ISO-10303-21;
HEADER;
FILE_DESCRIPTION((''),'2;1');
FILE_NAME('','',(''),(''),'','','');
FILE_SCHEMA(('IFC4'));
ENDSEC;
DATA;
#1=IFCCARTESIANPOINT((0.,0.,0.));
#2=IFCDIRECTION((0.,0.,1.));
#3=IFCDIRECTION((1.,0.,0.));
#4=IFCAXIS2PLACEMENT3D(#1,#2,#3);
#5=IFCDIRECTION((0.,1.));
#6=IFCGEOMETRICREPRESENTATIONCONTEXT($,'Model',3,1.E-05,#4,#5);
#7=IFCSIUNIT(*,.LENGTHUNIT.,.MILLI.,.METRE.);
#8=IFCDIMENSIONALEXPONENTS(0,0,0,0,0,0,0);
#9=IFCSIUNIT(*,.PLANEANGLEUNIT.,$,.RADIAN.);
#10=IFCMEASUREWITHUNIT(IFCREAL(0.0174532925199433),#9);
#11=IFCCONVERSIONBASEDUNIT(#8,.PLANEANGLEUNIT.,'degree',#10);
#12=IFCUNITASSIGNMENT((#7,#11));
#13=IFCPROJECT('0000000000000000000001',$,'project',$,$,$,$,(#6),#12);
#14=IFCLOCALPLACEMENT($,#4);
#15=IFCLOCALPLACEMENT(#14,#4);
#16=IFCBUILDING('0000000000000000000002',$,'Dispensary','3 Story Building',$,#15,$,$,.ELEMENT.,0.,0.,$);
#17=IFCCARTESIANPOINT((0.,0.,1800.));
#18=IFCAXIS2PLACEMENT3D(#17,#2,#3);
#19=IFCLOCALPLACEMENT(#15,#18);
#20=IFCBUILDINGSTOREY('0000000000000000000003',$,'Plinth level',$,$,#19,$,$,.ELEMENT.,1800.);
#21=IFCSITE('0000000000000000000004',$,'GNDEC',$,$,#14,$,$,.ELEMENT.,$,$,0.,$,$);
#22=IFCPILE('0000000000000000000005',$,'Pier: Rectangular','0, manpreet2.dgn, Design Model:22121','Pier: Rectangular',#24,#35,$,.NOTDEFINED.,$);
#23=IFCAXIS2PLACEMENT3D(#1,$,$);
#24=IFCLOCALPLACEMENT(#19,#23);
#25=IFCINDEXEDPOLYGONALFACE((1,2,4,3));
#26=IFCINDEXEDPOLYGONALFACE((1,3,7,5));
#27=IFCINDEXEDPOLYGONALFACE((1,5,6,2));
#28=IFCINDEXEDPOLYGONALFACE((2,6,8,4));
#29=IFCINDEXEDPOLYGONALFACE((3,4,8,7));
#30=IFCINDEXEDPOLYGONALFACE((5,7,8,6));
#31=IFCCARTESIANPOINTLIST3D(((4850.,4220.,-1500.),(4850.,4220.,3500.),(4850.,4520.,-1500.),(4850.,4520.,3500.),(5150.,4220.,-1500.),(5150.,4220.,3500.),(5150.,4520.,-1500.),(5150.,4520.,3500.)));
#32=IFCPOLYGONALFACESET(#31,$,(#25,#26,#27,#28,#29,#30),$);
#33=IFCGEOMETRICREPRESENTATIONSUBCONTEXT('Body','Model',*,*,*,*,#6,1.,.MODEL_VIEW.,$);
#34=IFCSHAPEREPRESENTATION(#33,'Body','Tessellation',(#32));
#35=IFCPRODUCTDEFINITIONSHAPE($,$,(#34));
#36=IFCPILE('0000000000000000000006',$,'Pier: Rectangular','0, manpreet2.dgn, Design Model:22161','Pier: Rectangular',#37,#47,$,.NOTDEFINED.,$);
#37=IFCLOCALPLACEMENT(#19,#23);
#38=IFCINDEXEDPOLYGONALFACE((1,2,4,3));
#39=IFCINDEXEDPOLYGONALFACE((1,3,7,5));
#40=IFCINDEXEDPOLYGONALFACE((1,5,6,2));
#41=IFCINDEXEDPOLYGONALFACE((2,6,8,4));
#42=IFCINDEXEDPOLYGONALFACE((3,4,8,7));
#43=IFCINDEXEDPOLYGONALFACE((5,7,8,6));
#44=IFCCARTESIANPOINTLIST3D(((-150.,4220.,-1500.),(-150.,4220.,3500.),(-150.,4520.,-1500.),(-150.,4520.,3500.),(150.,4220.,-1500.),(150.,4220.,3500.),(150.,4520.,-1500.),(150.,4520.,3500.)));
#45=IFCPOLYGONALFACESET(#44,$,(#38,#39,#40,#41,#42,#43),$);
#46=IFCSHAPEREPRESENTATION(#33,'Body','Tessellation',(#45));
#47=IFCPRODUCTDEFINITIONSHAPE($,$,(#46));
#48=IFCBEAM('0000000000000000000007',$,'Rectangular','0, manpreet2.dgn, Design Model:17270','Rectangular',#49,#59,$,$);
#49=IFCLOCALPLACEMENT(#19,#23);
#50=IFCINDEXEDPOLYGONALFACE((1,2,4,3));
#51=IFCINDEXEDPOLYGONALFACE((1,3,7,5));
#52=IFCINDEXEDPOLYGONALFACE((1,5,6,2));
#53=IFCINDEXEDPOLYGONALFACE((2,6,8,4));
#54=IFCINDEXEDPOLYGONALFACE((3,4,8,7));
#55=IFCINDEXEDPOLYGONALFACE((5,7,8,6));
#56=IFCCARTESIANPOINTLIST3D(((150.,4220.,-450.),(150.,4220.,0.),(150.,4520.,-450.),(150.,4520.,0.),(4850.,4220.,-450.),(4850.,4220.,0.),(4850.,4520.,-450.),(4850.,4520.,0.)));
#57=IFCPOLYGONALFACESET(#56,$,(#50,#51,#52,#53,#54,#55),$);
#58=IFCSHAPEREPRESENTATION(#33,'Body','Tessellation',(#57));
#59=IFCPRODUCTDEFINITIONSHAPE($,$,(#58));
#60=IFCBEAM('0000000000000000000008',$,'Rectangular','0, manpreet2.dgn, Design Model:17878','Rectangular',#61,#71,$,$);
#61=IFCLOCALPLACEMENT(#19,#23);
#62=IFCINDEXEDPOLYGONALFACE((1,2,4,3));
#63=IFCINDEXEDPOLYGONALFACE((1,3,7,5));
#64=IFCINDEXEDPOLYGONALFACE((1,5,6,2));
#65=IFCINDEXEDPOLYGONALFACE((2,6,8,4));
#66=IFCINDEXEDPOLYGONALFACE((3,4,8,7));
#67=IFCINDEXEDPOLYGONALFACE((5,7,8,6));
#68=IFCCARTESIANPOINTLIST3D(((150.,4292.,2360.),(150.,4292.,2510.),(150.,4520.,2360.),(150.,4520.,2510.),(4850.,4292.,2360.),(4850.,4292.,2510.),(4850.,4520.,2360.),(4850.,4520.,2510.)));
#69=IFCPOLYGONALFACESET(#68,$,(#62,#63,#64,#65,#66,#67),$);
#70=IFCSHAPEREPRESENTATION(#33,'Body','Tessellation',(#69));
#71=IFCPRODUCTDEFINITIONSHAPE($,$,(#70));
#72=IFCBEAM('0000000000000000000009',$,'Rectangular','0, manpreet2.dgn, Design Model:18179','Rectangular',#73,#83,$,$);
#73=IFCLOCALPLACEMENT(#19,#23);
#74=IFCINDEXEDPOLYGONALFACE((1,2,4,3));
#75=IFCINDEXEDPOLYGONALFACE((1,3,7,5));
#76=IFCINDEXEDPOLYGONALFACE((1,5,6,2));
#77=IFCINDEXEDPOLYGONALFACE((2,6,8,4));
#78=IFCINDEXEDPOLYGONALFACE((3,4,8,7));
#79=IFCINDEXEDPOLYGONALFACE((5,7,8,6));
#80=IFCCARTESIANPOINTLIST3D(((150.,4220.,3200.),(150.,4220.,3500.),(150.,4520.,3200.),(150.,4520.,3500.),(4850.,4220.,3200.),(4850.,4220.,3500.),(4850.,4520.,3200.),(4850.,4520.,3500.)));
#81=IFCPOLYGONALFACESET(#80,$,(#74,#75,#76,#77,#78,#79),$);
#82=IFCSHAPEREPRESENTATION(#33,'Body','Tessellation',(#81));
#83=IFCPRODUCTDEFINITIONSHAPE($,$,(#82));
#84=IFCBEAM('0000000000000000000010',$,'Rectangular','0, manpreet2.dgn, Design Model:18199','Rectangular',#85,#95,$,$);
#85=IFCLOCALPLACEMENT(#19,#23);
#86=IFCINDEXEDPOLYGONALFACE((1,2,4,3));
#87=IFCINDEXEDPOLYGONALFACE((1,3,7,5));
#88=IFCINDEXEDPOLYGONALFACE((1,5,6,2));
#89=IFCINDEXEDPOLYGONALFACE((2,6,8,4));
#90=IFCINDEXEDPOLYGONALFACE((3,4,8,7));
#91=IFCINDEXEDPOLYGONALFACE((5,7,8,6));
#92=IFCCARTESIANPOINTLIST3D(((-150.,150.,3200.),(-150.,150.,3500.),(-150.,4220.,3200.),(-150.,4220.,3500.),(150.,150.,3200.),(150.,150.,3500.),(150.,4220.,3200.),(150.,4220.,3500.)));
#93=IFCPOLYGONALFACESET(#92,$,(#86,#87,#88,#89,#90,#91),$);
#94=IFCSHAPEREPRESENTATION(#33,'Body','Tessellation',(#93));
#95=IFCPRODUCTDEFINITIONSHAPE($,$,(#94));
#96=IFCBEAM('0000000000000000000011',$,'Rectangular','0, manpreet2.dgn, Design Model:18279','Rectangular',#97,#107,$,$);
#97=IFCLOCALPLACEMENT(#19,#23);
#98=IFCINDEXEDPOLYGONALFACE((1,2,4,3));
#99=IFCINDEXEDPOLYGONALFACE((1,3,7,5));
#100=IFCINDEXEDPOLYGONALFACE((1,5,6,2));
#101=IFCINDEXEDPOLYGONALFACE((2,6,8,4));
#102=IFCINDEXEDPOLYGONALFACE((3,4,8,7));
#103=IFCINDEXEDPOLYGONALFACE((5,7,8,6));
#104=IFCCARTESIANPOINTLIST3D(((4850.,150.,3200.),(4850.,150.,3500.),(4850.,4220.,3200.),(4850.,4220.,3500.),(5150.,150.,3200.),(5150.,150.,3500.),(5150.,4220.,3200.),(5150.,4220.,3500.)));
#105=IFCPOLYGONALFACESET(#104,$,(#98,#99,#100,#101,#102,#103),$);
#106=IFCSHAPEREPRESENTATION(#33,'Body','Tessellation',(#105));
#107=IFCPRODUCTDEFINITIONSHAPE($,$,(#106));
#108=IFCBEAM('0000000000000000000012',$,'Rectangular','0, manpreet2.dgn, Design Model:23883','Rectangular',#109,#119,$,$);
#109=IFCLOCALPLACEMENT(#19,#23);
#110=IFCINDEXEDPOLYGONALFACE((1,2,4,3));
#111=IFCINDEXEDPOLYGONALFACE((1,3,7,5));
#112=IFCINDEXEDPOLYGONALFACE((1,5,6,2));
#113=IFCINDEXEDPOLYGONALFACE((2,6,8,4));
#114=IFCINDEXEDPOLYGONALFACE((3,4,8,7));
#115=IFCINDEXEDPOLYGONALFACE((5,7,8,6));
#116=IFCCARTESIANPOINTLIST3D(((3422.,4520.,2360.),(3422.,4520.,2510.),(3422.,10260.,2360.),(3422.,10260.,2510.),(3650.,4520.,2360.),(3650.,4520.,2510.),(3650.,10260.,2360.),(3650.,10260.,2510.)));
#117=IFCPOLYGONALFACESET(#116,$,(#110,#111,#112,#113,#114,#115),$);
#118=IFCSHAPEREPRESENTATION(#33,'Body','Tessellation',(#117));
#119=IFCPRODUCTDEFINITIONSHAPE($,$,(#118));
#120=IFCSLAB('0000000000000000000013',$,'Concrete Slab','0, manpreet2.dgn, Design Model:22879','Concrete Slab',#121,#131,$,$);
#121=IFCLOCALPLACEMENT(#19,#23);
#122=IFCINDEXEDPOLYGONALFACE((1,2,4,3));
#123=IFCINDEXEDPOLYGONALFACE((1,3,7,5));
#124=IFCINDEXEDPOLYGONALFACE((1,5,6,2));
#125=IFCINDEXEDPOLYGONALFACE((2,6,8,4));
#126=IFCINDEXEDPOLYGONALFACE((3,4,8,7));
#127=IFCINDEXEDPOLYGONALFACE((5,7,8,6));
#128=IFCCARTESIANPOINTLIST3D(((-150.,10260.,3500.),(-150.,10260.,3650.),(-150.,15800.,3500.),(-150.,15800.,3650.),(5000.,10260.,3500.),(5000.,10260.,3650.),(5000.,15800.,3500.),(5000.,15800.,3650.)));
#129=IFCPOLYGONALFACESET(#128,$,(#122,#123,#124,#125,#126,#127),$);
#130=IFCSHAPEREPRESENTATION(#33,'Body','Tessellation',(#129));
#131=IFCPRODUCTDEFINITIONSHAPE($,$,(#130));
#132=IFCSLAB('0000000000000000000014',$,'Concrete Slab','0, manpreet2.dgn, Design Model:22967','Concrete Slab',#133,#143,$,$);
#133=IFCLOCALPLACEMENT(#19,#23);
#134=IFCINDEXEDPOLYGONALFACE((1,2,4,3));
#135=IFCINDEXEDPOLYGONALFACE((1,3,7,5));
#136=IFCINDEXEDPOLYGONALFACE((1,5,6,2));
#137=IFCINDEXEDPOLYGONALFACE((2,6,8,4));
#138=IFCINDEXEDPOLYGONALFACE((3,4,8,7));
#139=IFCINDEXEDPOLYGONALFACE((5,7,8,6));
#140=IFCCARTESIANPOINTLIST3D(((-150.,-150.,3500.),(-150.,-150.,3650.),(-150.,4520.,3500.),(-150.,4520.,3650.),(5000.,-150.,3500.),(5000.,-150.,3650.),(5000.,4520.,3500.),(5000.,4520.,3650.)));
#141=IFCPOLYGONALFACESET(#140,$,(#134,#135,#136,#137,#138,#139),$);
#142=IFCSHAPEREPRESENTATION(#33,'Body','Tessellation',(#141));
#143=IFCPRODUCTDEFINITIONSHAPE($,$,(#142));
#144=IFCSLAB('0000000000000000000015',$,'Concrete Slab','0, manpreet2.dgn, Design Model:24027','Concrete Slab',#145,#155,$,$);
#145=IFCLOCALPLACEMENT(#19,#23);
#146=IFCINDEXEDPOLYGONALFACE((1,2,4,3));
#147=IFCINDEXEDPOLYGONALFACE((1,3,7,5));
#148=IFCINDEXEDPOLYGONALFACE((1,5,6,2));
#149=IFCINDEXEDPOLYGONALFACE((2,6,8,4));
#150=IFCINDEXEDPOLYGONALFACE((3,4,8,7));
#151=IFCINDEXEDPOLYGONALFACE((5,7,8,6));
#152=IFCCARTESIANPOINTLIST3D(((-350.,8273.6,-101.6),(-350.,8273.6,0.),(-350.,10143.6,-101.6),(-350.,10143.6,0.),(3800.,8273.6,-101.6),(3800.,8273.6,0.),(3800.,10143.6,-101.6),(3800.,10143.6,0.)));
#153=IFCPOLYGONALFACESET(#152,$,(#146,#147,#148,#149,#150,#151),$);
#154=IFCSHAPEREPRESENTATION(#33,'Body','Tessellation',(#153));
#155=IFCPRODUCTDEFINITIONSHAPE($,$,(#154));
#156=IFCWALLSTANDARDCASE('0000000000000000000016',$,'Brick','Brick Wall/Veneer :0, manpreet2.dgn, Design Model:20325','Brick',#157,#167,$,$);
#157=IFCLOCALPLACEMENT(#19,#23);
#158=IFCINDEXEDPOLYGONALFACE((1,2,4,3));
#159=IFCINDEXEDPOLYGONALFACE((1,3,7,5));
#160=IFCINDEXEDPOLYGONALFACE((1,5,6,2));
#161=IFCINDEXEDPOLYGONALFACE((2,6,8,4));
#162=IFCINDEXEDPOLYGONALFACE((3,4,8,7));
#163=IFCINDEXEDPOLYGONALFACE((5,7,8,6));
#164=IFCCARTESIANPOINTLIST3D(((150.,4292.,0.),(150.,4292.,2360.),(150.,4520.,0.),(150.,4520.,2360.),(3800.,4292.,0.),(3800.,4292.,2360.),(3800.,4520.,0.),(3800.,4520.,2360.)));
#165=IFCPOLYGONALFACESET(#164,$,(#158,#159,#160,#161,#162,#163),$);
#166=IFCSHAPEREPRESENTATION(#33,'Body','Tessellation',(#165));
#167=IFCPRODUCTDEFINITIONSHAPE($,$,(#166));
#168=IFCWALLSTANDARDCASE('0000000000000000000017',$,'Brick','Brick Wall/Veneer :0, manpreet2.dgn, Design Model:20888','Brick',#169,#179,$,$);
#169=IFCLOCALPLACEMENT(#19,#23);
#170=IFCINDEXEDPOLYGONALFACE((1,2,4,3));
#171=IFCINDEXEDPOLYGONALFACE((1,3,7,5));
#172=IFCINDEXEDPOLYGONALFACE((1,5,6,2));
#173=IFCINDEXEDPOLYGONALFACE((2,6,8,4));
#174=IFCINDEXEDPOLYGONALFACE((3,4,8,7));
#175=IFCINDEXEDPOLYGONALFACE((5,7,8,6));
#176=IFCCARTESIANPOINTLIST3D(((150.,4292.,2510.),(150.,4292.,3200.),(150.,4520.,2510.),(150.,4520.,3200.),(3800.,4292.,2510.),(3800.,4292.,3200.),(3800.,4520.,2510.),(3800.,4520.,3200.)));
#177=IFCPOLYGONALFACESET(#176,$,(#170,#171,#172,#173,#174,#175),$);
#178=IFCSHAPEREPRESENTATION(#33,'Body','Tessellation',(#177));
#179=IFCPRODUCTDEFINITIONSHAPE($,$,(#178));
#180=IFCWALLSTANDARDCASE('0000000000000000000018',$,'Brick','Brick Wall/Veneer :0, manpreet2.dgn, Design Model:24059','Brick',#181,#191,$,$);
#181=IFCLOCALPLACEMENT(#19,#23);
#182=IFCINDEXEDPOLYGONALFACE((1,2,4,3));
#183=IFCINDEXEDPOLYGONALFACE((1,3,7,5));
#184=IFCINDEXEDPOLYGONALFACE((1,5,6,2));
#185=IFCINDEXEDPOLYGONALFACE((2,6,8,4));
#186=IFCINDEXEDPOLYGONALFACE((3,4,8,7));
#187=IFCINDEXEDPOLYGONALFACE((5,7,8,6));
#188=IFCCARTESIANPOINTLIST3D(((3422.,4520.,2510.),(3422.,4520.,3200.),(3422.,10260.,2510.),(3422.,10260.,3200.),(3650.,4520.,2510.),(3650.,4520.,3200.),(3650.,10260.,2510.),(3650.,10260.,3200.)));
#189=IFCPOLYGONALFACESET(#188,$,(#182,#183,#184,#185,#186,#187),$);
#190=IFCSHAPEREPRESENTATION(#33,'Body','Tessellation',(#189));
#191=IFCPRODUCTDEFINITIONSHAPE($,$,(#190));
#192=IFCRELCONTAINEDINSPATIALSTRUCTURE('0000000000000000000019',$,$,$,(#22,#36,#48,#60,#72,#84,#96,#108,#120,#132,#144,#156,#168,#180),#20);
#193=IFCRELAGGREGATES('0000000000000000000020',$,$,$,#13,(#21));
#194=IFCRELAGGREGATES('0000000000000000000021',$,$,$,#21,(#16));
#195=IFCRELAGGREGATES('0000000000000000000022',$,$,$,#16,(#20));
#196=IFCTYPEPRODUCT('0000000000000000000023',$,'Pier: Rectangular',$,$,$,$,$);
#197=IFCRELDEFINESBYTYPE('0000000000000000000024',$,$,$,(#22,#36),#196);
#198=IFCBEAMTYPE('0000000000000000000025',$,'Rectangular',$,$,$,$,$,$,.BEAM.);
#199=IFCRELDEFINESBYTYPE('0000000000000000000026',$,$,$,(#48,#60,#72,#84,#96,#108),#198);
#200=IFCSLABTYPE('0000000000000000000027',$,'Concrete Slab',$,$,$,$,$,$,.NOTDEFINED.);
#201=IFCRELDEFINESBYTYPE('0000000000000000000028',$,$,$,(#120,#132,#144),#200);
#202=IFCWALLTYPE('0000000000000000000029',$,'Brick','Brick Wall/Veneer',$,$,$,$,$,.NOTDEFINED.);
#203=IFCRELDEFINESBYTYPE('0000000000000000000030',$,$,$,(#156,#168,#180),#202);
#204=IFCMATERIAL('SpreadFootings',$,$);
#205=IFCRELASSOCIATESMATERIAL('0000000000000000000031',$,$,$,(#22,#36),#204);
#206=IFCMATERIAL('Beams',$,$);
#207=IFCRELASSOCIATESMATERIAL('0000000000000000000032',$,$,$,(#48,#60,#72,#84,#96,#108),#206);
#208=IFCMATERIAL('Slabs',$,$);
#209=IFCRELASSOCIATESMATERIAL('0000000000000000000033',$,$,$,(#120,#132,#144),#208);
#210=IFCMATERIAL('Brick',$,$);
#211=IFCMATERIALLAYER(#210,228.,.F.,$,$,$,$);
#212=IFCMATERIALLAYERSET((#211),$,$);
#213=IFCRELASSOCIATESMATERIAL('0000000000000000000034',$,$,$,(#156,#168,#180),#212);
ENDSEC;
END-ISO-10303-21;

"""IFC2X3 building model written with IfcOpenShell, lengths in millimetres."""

from ifc_helpers import new_model, entity, si_unit, converted_unit, direction, frame, frame_2d, origin_with_axes, place, context, subcontext, project, spatial, rectangle, extrude, material, layer, layer_set, layer_usage, type_object, element, save


model = new_model("IFC2X3")

# Units and contexts
model_context = context("Model", 3, precision=1e-05, world=origin_with_axes(), true_north=direction((0.0, 1.0)))
body_context = subcontext(model_context, "Body", "Model", "MODEL_VIEW", scale=1.0)
ifc_project = project(units=[si_unit("LENGTHUNIT", "METRE", prefix="MILLI"), converted_unit("PLANEANGLEUNIT", "degree", entity("IfcReal", 0.0174532925199433), si_unit("PLANEANGLEUNIT", "RADIAN"), dimensions=[0, 0, 0, 0, 0, 0, 0])], contexts=[model_context])

# Site, building, storey
site_placement = place(None, origin_with_axes())
site = spatial("IfcSite", under=ifc_project, at=site_placement, Name="GNDEC", CompositionType="ELEMENT", RefElevation=0.0)
building_placement = place(site_placement, origin_with_axes())
building = spatial("IfcBuilding", under=site, at=building_placement, Name="Dispensary", Description="3 Story Building", CompositionType="ELEMENT", ElevationOfRefHeight=0.0, ElevationOfTerrain=0.0)
storey_placement = place(building_placement, frame((0.0, 0.0, 1800.0), z_axis=(0.0, 0.0, 1.0), x_axis=(1.0, 0.0, 0.0)))
storey = spatial("IfcBuildingStorey", under=building, at=storey_placement, Name="Plinth level", CompositionType="ELEMENT", Elevation=1800.0)

# Piles
ifc_material_1 = material(Name="SpreadFootings")
type_product = type_object("IfcTypeProduct", Name="Pier: Rectangular")
for number, where, z_axis, x_axis, name, description in (
    (1, (4850.0, 4520.0, -1500.0), (0.0, 0.0, 1.0), (0.0, -1.0, 0.0), "Pier: Rectangular", "0, manpreet2.dgn, Design Model:22121"),
    (2, (-150.0, 4520.0, -1500.0), (0.0, 0.0, 1.0), (0.0, -1.0, 0.0), "Pier: Rectangular", "0, manpreet2.dgn, Design Model:22161"),
):
    element("IfcPile", number, at=place(storey_placement, frame(where, z_axis=z_axis, x_axis=x_axis)), inside=storey, type_object=type_product, material=ifc_material_1, Name=name, Description=description, ObjectType="Pier: Rectangular", PredefinedType="NOTDEFINED", context=body_context, shape_type="SweptSolid", body=[
        extrude(rectangle(XDim=300.0, YDim=300.0, at=frame_2d((150.0, 150.0), x_axis=(0.0, 1.0))), origin_with_axes(), (0.0, 0.0, 1.0), 5000.0),
    ])

# Beams
ifc_material_2 = material(Name="Beams")
beam_type = type_object("IfcBeamType", Name="Rectangular", PredefinedType="BEAM")
beam_1_placement = place(storey_placement, frame((150.0, 4520.0, -450.0), z_axis=(1.0, 0.0, 0.0), x_axis=(0.0, 0.0, 1.0)))
element("IfcBeam", 3, at=beam_1_placement, inside=storey, type_object=beam_type, material=ifc_material_2, Name="Rectangular", Description="0, manpreet2.dgn, Design Model:17270", ObjectType="Rectangular", context=body_context, shape_type="SweptSolid", body=[
    extrude(rectangle(XDim=300.0, YDim=450.0, at=frame_2d((225.0, 150.0), x_axis=(0.0, 1.0))), origin_with_axes(), (0.0, 0.0, 1.0), 4700.0),
])
beam_2_placement = place(storey_placement, frame((150.0, 4292.0, 2360.0), z_axis=(1.0, 0.0, 0.0), x_axis=(0.0, 1.0, 0.0)))
element("IfcBeam", 4, at=beam_2_placement, inside=storey, type_object=beam_type, material=ifc_material_2, Name="Rectangular", Description="0, manpreet2.dgn, Design Model:17878", ObjectType="Rectangular", context=body_context, shape_type="SweptSolid", body=[
    extrude(rectangle(XDim=150.0, YDim=228.0, at=frame_2d((114.0, 75.0), x_axis=(0.0, 1.0))), origin_with_axes(), (0.0, 0.0, 1.0), 4700.0),
])
beam_3_placement = place(storey_placement, frame((150.0, 4220.0, 3200.0), z_axis=(1.0, 0.0, 0.0), x_axis=(0.0, 1.0, 0.0)))
element("IfcBeam", 5, at=beam_3_placement, inside=storey, type_object=beam_type, material=ifc_material_2, Name="Rectangular", Description="0, manpreet2.dgn, Design Model:18179", ObjectType="Rectangular", context=body_context, shape_type="SweptSolid", body=[
    extrude(rectangle(XDim=300.0, YDim=300.0, at=frame_2d((150.0, 150.0), x_axis=(0.0, 1.0))), origin_with_axes(), (0.0, 0.0, 1.0), 4700.0),
])
for number, where, z_axis, x_axis, name, description in (
    (6, (-150.0, 4220.0, 3200.0), (0.0, -1.0, 0.0), (1.0, 0.0, 0.0), "Rectangular", "0, manpreet2.dgn, Design Model:18199"),
    (7, (4850.0, 4220.0, 3200.0), (0.0, -1.0, 0.0), (1.0, 0.0, 0.0), "Rectangular", "0, manpreet2.dgn, Design Model:18279"),
):
    element("IfcBeam", number, at=place(storey_placement, frame(where, z_axis=z_axis, x_axis=x_axis)), inside=storey, type_object=beam_type, material=ifc_material_2, Name=name, Description=description, ObjectType="Rectangular", context=body_context, shape_type="SweptSolid", body=[
        extrude(rectangle(XDim=300.0, YDim=300.0, at=frame_2d((150.0, 150.0), x_axis=(0.0, 1.0))), origin_with_axes(), (0.0, 0.0, 1.0), 4070.0),
    ])
beam_4_placement = place(storey_placement, frame((3650.0, 4520.0, 2360.0), z_axis=(0.0, 1.0, 0.0), x_axis=(-1.0, 0.0, 0.0)))
element("IfcBeam", 8, at=beam_4_placement, inside=storey, type_object=beam_type, material=ifc_material_2, Name="Rectangular", Description="0, manpreet2.dgn, Design Model:23883", ObjectType="Rectangular", context=body_context, shape_type="SweptSolid", body=[
    extrude(rectangle(XDim=150.0, YDim=228.0, at=frame_2d((114.0, 75.0), x_axis=(0.0, 1.0))), origin_with_axes(), (0.0, 0.0, 1.0), 5740.0),
])

# Slabs
ifc_material_3 = material(Name="Slabs")
slab_type = type_object("IfcSlabType", Name="Concrete Slab", PredefinedType="NOTDEFINED")
slab_1_placement = place(storey_placement, frame((-150.0, 10260.0, 3500.0), z_axis=(0.0, 0.0, 1.0), x_axis=(1.0, 0.0, 0.0)))
element("IfcSlab", 9, at=slab_1_placement, inside=storey, type_object=slab_type, material=ifc_material_3, Name="Concrete Slab", Description="0, manpreet2.dgn, Design Model:22879", ObjectType="Concrete Slab", context=body_context, shape_type="SweptSolid", body=[
    extrude(rectangle(XDim=5150.0, YDim=5540.0, at=frame_2d((2575.0, 2770.0), x_axis=(1.0, 0.0))), origin_with_axes(), (0.0, 0.0, 1.0), 150.0),
])
slab_2_placement = place(storey_placement, frame((-150.0, 4520.0, 3500.0), z_axis=(0.0, 0.0, 1.0), x_axis=(0.0, -1.0, 0.0)))
element("IfcSlab", 10, at=slab_2_placement, inside=storey, type_object=slab_type, material=ifc_material_3, Name="Concrete Slab", Description="0, manpreet2.dgn, Design Model:22967", ObjectType="Concrete Slab", context=body_context, shape_type="SweptSolid", body=[
    extrude(rectangle(XDim=4670.0, YDim=5150.0, at=frame_2d((2335.0, 2575.0), x_axis=(1.0, 0.0))), origin_with_axes(), (0.0, 0.0, 1.0), 150.0),
])
slab_3_placement = place(storey_placement, frame((3800.0, 8273.6, 0.0), z_axis=(0.0, 0.0, -1.0), x_axis=(-1.0, 0.0, 0.0)))
element("IfcSlab", 11, at=slab_3_placement, inside=storey, type_object=slab_type, material=ifc_material_3, Name="Concrete Slab", Description="0, manpreet2.dgn, Design Model:24027", ObjectType="Concrete Slab", context=body_context, shape_type="SweptSolid", body=[
    extrude(rectangle(XDim=4150.0, YDim=1870.0, at=frame_2d((2075.0, 935.0), x_axis=(1.0, 0.0))), origin_with_axes(), (0.0, 0.0, 1.0), 101.6),
])

# Walls
ifc_material_4 = material(Name="Brick")
ifc_layer = layer(ifc_material_4, 228.0, ventilated=False)
ifc_layer_set = layer_set([ifc_layer])
ifc_layer_usage = layer_usage(ifc_layer_set, "AXIS2", "POSITIVE", 0.0)
wall_type = type_object("IfcWallType", Name="Brick", Description="Brick Wall/Veneer", PredefinedType="NOTDEFINED")
wall_1_placement = place(storey_placement, frame((150.0, 4520.0, 0.0), z_axis=(0.0, 0.0, 1.0), x_axis=(1.0, 0.0, 0.0)))
element("IfcWallStandardCase", 12, at=wall_1_placement, inside=storey, type_object=wall_type, material=ifc_layer_usage, Name="Brick", Description="Brick Wall/Veneer :0, manpreet2.dgn, Design Model:20325", ObjectType="Brick", context=body_context, shape_type="SweptSolid", body=[
    extrude(rectangle(XDim=3650.0, YDim=228.0, at=frame_2d((1825.0, -114.0), x_axis=(-1.0, 0.0))), origin_with_axes(), (0.0, 0.0, 1.0), 2360.0),
])
wall_2_placement = place(storey_placement, frame((150.0, 4520.0, 2510.0), z_axis=(0.0, 0.0, 1.0), x_axis=(1.0, 0.0, 0.0)))
element("IfcWallStandardCase", 13, at=wall_2_placement, inside=storey, type_object=wall_type, material=ifc_layer_usage, Name="Brick", Description="Brick Wall/Veneer :0, manpreet2.dgn, Design Model:20888", ObjectType="Brick", context=body_context, shape_type="SweptSolid", body=[
    extrude(rectangle(XDim=3650.0, YDim=228.0, at=frame_2d((1825.0, -114.0), x_axis=(-1.0, 0.0))), origin_with_axes(), (0.0, 0.0, 1.0), 690.0),
])
wall_3_placement = place(storey_placement, frame((3422.0, 4522.0, 2510.0), z_axis=(0.0, 0.0, 1.0), x_axis=(0.0, 1.0, 0.0)))
element("IfcWallStandardCase", 14, at=wall_3_placement, inside=storey, type_object=wall_type, material=ifc_layer_usage, Name="Brick", Description="Brick Wall/Veneer :0, manpreet2.dgn, Design Model:24059", ObjectType="Brick", context=body_context, shape_type="SweptSolid", body=[
    extrude(rectangle(XDim=5740.0, YDim=228.0, at=frame_2d((2868.0, -114.0), x_axis=(-1.0, 0.0))), origin_with_axes(), (0.0, 0.0, 1.0), 690.0),
])

save(model, "model.ifc")
